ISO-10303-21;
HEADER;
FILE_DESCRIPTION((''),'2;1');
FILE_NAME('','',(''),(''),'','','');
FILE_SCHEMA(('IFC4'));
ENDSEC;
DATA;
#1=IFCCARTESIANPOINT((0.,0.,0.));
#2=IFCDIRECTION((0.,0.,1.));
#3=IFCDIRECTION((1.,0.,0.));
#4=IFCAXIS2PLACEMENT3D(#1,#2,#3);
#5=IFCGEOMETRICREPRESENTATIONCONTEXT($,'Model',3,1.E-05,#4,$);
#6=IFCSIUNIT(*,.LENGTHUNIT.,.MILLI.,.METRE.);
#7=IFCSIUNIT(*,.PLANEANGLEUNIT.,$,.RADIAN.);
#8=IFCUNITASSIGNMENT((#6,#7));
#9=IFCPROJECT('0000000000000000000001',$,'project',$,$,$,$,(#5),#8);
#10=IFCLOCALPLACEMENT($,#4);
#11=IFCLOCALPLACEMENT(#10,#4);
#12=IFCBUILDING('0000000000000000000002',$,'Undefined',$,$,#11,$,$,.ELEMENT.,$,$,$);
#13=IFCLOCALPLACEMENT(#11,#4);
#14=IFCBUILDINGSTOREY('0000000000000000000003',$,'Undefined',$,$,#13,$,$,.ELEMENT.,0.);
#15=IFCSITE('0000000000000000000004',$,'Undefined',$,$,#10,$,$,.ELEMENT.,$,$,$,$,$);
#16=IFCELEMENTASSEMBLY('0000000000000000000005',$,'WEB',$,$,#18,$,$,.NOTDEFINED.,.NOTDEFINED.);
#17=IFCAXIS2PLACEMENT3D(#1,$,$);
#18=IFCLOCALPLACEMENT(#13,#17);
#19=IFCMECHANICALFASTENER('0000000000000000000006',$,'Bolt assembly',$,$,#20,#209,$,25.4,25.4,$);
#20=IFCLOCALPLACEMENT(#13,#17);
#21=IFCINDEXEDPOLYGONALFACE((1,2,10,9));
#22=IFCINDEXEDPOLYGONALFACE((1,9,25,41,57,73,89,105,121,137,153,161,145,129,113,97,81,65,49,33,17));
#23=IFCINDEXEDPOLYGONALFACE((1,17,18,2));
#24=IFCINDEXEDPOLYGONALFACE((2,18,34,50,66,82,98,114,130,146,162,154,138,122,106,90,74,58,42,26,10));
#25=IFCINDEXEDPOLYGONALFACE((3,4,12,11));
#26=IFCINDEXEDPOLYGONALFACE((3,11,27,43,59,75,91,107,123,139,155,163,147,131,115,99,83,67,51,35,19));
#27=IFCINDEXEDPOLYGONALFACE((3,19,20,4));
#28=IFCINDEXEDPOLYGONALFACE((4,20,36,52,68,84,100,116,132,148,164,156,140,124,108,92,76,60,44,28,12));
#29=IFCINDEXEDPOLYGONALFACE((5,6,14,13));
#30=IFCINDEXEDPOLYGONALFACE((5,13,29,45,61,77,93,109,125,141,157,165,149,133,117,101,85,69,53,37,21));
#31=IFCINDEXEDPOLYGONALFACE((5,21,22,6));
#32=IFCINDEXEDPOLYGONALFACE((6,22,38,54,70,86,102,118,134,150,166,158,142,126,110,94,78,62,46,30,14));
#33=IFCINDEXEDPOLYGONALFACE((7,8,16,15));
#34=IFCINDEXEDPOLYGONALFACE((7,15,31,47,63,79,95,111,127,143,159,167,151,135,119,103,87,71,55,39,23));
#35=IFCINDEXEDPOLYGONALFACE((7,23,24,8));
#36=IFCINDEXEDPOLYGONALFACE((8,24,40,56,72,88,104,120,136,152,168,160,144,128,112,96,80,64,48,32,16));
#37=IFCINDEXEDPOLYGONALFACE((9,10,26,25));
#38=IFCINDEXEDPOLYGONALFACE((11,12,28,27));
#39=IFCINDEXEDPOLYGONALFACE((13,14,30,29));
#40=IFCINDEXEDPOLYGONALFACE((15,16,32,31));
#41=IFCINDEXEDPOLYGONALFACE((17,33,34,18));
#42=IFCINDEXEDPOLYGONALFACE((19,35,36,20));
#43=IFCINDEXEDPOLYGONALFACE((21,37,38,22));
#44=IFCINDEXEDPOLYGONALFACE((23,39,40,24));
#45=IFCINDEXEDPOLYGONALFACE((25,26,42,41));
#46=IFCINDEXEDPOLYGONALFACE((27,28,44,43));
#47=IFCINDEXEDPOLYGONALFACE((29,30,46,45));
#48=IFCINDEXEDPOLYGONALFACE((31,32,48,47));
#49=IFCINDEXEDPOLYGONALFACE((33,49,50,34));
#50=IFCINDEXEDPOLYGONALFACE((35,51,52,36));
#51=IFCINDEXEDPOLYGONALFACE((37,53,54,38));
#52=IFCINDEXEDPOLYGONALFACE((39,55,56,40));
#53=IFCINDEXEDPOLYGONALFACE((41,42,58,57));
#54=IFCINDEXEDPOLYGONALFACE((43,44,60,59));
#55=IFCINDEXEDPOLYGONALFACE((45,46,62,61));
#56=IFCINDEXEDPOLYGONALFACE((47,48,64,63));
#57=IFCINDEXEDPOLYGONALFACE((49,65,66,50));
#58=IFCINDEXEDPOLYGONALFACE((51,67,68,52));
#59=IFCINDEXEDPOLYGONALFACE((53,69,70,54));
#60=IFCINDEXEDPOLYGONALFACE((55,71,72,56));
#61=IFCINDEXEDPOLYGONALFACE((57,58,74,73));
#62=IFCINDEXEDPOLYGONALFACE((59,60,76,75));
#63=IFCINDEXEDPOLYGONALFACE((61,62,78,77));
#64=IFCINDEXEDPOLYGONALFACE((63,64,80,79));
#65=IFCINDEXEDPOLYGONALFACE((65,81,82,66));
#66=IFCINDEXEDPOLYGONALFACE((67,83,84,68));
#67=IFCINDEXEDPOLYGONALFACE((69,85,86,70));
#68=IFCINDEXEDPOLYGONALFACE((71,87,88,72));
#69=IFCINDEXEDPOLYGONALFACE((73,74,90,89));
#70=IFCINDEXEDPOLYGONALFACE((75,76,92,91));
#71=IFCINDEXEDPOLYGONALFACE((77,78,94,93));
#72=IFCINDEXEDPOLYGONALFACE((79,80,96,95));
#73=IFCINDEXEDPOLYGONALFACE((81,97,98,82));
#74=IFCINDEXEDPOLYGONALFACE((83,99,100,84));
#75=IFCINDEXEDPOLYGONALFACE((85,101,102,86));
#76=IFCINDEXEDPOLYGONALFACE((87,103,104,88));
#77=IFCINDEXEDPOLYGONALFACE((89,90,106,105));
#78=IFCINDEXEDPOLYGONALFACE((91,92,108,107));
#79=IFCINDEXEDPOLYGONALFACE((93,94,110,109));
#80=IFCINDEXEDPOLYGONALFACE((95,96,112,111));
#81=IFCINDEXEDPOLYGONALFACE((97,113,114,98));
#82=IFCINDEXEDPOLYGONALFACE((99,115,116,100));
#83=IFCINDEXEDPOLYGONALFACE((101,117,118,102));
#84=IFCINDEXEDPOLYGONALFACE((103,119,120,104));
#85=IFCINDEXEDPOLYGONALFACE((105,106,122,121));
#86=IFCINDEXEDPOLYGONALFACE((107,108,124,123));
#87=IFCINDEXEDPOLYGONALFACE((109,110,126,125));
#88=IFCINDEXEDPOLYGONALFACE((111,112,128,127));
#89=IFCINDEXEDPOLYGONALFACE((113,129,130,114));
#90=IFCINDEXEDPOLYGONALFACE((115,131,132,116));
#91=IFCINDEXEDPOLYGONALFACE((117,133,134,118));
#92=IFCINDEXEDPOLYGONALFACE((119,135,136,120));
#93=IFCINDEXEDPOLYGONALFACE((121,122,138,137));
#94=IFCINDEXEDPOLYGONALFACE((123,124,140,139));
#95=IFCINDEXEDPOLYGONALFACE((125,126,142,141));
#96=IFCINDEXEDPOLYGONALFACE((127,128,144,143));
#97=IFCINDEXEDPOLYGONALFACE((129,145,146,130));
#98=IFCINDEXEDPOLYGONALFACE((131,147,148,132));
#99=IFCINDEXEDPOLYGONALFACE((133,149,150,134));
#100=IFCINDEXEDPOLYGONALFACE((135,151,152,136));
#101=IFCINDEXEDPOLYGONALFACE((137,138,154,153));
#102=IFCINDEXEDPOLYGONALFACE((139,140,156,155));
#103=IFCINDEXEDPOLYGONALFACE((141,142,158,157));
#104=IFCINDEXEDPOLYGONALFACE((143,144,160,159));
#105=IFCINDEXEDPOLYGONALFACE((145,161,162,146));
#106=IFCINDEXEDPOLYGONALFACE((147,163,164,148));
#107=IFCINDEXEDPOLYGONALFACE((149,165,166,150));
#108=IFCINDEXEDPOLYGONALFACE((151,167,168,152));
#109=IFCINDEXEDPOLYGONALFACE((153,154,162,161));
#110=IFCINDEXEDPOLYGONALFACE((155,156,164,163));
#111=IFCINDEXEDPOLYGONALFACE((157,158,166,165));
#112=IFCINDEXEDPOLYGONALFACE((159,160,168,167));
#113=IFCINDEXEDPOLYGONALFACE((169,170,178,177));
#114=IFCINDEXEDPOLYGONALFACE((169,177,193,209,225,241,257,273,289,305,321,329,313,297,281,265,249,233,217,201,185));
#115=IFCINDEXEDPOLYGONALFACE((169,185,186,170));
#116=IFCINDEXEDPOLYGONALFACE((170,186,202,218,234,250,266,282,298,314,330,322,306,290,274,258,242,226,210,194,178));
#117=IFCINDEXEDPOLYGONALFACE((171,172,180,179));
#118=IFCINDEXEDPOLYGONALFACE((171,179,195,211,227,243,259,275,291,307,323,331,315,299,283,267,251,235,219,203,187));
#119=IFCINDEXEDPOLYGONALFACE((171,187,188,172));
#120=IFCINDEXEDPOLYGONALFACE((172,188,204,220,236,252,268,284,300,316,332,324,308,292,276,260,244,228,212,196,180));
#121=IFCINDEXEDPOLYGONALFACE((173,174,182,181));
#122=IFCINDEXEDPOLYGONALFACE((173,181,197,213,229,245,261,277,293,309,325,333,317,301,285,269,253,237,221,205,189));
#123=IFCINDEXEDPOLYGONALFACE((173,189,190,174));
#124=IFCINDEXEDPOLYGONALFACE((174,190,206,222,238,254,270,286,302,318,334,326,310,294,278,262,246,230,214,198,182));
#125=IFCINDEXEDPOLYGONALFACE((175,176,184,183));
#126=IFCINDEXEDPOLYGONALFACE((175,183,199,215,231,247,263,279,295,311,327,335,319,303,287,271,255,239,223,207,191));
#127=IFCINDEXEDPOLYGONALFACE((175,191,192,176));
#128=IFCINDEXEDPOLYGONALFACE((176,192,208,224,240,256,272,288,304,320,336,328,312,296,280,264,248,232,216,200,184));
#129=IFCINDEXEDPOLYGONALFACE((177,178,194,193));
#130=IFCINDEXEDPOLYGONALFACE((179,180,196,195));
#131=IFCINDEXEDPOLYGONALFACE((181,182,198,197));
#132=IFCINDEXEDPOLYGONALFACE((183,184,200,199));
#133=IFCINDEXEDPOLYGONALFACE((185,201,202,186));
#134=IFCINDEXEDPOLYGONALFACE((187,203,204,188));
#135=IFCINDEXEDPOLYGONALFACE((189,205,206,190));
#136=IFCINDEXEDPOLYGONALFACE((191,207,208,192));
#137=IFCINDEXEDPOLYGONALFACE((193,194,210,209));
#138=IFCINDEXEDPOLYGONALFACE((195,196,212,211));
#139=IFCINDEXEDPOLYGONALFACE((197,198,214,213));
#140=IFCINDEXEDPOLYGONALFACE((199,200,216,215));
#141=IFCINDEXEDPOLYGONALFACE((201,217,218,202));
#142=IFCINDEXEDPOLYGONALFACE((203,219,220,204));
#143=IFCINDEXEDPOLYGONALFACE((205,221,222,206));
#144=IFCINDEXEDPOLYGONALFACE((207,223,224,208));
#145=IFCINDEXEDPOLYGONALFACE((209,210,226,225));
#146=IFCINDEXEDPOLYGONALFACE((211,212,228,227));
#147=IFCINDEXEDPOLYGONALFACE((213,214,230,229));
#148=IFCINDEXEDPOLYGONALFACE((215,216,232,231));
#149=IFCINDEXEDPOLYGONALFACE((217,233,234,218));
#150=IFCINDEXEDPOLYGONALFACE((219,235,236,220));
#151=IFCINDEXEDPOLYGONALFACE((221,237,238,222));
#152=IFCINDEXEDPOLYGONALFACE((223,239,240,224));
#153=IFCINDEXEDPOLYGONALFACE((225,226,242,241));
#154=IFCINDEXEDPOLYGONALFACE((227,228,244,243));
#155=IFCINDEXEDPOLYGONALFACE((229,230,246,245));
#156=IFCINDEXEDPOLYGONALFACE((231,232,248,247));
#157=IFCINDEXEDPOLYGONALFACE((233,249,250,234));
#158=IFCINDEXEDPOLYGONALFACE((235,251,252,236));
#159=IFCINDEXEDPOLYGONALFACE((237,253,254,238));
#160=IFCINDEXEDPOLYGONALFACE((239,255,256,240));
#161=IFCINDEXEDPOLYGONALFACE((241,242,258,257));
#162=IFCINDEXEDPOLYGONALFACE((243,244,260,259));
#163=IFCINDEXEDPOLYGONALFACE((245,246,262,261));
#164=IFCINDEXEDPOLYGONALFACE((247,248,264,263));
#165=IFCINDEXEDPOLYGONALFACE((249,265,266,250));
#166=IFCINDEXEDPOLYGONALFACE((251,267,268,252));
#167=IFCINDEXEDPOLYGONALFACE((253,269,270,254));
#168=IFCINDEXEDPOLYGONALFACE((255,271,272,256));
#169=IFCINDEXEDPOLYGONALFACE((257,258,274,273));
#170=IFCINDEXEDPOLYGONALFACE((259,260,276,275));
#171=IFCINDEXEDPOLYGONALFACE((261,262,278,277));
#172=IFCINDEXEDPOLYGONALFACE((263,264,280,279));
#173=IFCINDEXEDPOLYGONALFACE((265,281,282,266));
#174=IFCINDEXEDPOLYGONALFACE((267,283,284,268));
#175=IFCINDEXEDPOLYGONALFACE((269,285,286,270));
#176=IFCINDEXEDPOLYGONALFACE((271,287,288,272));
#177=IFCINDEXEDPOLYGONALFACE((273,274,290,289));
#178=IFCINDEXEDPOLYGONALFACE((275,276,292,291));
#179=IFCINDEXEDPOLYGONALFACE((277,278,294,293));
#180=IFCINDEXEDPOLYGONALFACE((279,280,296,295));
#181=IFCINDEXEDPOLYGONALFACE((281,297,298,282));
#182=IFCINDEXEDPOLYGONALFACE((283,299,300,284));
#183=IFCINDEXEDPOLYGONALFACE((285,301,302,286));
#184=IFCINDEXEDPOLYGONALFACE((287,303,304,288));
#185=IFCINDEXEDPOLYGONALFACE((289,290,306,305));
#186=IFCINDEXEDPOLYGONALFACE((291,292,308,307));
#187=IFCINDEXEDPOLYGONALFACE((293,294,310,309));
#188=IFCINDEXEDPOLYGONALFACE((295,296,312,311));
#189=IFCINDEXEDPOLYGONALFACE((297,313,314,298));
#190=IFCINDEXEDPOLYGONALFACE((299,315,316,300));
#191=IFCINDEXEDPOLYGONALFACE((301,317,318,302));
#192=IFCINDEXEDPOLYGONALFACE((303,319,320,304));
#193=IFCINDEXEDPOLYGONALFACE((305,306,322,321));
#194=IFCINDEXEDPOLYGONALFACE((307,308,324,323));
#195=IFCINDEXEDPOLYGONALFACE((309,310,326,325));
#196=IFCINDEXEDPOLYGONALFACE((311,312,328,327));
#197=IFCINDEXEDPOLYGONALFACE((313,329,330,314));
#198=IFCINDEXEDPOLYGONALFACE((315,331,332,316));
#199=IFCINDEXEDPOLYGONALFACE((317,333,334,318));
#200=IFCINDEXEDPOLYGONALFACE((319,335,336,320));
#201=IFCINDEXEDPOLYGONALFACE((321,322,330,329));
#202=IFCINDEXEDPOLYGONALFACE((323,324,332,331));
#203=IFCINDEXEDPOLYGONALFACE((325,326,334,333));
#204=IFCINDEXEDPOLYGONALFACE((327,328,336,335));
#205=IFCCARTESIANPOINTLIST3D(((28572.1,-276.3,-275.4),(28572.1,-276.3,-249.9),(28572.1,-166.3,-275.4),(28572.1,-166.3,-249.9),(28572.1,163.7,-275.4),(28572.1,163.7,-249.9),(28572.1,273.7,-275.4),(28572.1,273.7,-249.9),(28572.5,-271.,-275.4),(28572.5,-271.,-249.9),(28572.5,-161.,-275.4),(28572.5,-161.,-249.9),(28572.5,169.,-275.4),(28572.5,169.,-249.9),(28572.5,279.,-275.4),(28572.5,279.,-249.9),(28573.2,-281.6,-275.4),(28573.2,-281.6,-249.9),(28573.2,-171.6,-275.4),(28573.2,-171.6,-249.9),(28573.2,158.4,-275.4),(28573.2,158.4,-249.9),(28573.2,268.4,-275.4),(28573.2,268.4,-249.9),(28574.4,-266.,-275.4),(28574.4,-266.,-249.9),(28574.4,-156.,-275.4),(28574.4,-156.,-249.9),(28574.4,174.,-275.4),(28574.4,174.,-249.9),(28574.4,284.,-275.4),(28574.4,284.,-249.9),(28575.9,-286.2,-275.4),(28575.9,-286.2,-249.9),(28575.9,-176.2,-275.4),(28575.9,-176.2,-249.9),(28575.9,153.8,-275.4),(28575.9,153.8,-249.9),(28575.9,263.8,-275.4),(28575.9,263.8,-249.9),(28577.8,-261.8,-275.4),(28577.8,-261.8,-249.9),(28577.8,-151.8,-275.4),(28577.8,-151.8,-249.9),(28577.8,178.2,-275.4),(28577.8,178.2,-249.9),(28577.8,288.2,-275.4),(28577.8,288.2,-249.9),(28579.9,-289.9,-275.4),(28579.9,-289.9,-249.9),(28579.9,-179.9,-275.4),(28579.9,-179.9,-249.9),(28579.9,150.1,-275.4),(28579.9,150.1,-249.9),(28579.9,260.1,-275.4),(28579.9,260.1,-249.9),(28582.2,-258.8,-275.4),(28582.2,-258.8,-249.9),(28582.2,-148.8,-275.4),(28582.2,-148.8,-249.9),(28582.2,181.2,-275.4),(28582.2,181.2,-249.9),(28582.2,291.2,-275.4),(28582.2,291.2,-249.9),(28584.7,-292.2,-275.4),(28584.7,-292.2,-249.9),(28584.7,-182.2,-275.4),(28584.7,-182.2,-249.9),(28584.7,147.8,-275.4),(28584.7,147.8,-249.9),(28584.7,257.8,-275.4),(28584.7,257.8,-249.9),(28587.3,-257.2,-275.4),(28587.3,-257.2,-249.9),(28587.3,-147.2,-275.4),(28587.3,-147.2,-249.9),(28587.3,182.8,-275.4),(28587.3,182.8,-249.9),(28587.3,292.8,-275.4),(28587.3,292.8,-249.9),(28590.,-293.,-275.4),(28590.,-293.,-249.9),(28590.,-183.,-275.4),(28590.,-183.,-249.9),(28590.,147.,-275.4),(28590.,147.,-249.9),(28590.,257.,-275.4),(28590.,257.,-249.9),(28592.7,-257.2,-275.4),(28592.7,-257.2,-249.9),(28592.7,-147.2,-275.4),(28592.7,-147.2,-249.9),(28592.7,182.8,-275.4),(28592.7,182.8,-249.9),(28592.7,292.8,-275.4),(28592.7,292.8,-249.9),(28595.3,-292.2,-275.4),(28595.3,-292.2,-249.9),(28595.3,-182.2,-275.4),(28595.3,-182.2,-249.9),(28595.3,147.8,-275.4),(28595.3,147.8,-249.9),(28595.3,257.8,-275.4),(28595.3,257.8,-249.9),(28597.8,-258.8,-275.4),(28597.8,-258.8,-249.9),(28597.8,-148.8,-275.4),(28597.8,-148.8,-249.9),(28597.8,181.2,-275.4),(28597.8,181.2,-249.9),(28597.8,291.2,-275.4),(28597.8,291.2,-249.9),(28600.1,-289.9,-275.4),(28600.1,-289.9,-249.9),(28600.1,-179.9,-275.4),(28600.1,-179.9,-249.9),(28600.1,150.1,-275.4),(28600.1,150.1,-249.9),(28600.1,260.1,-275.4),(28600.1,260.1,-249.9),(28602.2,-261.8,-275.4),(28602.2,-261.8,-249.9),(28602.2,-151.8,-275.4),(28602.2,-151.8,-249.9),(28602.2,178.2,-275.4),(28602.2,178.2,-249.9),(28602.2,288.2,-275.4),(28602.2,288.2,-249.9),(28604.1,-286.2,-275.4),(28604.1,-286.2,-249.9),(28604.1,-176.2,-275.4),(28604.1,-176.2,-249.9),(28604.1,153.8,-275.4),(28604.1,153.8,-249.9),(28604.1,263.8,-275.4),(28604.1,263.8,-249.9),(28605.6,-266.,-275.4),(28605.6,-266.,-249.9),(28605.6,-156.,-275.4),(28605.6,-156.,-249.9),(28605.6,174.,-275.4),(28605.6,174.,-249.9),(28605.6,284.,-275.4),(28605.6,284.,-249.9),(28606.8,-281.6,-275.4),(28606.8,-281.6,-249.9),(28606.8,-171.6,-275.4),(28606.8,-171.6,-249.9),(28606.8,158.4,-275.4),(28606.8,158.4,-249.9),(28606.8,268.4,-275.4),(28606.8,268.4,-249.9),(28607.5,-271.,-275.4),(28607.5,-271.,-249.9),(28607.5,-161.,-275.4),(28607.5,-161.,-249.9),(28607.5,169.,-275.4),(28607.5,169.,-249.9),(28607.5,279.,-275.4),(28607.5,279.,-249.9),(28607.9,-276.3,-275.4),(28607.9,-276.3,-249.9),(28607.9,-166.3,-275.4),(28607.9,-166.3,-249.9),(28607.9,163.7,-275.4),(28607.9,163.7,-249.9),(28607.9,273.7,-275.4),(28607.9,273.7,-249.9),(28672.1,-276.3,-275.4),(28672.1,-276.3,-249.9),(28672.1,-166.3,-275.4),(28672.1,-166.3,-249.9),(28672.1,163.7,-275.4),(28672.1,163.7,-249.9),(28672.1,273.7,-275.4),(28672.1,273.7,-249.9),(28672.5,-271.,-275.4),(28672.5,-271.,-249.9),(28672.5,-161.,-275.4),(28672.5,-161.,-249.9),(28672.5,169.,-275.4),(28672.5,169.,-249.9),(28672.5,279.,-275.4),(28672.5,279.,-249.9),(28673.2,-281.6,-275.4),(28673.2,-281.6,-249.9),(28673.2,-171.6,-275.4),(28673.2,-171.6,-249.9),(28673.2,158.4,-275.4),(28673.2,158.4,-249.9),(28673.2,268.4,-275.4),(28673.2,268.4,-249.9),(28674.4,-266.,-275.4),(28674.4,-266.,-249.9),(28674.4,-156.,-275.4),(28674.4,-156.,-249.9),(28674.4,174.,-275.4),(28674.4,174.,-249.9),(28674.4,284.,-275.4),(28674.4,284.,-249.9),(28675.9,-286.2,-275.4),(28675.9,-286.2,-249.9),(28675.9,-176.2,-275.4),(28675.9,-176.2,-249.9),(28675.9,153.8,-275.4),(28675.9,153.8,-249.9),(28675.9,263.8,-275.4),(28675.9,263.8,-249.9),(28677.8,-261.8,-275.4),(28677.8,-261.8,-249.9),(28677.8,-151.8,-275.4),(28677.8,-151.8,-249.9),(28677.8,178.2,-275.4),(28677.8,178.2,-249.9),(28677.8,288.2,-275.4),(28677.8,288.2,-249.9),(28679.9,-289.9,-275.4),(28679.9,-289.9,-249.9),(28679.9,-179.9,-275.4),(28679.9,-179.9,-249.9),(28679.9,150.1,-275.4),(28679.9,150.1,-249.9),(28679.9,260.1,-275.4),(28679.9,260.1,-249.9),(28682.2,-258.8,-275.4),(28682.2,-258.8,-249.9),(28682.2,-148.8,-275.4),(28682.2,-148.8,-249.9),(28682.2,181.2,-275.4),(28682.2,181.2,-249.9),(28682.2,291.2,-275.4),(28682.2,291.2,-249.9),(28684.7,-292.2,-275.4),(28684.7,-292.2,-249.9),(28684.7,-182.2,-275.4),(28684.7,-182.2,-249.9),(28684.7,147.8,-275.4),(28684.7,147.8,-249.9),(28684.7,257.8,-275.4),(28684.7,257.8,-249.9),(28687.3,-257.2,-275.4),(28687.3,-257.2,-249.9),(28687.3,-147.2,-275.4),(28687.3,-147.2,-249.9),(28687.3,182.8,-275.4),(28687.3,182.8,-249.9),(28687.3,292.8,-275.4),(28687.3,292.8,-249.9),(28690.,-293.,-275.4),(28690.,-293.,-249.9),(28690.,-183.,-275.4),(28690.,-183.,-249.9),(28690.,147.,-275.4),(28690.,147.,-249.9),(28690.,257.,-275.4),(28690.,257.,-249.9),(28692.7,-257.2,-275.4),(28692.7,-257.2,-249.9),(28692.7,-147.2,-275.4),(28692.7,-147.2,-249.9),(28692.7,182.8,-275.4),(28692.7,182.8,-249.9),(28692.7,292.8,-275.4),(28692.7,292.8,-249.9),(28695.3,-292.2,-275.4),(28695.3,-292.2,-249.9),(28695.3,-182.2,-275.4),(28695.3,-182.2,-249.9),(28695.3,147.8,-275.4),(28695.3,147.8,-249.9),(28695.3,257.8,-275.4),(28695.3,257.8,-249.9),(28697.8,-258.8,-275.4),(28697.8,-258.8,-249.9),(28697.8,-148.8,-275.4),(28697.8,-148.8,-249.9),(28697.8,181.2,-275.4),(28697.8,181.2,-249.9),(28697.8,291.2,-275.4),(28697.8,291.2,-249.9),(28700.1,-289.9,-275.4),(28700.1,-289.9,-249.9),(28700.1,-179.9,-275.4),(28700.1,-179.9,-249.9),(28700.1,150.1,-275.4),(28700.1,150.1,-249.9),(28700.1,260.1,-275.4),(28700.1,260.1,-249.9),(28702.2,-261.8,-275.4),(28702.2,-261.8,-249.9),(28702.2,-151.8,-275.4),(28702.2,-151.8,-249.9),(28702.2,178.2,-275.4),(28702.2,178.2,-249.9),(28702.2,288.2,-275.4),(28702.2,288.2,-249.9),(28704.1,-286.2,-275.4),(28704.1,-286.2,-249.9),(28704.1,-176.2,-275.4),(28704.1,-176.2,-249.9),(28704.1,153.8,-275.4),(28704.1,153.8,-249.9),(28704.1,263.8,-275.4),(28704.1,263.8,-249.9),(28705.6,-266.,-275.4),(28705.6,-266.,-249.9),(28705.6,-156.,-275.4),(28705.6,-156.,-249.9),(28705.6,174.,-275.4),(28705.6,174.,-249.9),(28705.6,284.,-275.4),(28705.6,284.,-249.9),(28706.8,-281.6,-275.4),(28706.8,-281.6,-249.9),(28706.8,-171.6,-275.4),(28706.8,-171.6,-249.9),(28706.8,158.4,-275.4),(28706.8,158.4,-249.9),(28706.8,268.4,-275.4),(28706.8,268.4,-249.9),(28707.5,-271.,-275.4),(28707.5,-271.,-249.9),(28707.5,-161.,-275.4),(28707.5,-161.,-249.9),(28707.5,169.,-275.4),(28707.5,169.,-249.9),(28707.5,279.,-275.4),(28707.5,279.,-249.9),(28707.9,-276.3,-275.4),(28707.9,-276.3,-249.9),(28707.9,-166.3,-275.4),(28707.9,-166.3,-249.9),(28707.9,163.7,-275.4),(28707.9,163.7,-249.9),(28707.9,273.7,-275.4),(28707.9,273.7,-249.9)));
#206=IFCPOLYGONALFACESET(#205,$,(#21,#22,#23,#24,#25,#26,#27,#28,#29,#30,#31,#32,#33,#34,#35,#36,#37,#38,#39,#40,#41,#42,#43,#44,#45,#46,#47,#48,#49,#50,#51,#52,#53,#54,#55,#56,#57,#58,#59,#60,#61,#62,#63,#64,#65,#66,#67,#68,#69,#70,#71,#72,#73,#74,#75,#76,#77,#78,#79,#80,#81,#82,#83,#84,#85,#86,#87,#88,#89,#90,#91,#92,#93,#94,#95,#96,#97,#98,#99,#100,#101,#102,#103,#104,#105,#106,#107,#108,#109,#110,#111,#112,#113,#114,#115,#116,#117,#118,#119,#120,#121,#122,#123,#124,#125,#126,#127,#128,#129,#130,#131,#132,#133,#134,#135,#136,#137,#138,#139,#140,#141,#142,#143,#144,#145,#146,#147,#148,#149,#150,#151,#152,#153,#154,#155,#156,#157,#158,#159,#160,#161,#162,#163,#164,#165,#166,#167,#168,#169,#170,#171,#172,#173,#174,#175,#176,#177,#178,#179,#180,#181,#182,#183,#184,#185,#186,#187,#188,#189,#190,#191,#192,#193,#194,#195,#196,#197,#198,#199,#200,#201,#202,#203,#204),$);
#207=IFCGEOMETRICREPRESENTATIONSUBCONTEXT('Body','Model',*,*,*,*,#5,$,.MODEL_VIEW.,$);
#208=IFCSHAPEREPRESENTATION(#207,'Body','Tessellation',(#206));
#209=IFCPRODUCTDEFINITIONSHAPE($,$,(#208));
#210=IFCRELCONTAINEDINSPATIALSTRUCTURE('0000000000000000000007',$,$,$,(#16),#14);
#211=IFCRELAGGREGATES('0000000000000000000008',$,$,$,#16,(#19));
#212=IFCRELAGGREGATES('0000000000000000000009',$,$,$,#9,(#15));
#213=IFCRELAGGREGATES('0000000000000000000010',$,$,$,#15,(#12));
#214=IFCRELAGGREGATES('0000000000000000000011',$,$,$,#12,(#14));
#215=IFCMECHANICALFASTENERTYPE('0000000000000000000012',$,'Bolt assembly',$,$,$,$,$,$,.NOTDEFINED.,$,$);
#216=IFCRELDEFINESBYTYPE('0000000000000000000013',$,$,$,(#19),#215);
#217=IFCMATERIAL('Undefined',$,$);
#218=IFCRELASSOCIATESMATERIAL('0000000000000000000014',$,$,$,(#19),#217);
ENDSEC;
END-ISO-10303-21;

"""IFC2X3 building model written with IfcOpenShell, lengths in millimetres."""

from ifc_helpers import new_model, si_unit, frame, origin_with_axes, origin_2d_with_axis, place, context, subcontext, project, spatial, circle, extrude, source, transform, mapped, material, type_object, element, aggregate, save


model = new_model("IFC2X3")

# Units and contexts
model_context = context("Model", 3, precision=1e-05, world=origin_with_axes())
body_context = subcontext(model_context, "Body", "Model", "MODEL_VIEW")
ifc_project = project(units=[si_unit("LENGTHUNIT", "METRE", prefix="MILLI"), si_unit("PLANEANGLEUNIT", "RADIAN")], contexts=[model_context])

# Site, building, storey
site_placement = place(None, origin_with_axes())
site = spatial("IfcSite", under=ifc_project, at=site_placement, Name="Undefined", CompositionType="ELEMENT")
building_placement = place(site_placement, origin_with_axes())
building = spatial("IfcBuilding", under=site, at=building_placement, Name="Undefined", CompositionType="ELEMENT")
storey_placement = place(building_placement, origin_with_axes())
storey = spatial("IfcBuildingStorey", under=building, at=storey_placement, Name="Undefined", CompositionType="ELEMENT", Elevation=0.0)

# Element assembly
assembly_1_placement = place(storey_placement, origin_with_axes())
assembly_1 = element("IfcElementAssembly", 1, at=assembly_1_placement, inside=storey, Name="WEB", AssemblyPlace="NOTDEFINED", PredefinedType="NOTDEFINED")

# Shared definitions
ifc_material_1 = material(Name="Undefined")
mechanical_fastener_type = type_object("IfcMechanicalFastenerType", Name="Bolt assembly")

# Mechanical fastener
shared_shape_1 = source(origin_with_axes(), body_context, "Body", "SweptSolid", [
    extrude(circle(Radius=18.0, at=origin_2d_with_axis()), frame((0.0, -8.0, 0.0), z_axis=(0.0, 1.0, 0.0), x_axis=(1.0, 0.0, 0.0)), (0.0, 0.0, 1.0), 25.5),
])
mechanical_fastener_1_placement = place(assembly_1_placement, frame((28640.0, 275.0, -267.4), z_axis=(-1.0, 0.0, 0.0), x_axis=(0.0, -1.0, 0.0)))
mechanical_fastener_1 = element("IfcMechanicalFastener", 2, at=mechanical_fastener_1_placement, type_object=mechanical_fastener_type, material=ifc_material_1, Name="Bolt assembly", NominalDiameter=25.4, NominalLength=25.4, context=body_context, shape_type="MappedRepresentation", body=[
    mapped(shared_shape_1, transform((0.0, 0.0, -50.0))),
    mapped(shared_shape_1, transform((110.0, 0.0, -50.0))),
    mapped(shared_shape_1, transform((440.0, 0.0, -50.0))),
    mapped(shared_shape_1, transform((550.0, 0.0, -50.0))),
    mapped(shared_shape_1, transform((0.0, 0.0, 50.0))),
    mapped(shared_shape_1, transform((110.0, 0.0, 50.0))),
    mapped(shared_shape_1, transform((440.0, 0.0, 50.0))),
    mapped(shared_shape_1, transform((550.0, 0.0, 50.0))),
])
aggregate(assembly_1, [mechanical_fastener_1])

save(model, "model.ifc")
